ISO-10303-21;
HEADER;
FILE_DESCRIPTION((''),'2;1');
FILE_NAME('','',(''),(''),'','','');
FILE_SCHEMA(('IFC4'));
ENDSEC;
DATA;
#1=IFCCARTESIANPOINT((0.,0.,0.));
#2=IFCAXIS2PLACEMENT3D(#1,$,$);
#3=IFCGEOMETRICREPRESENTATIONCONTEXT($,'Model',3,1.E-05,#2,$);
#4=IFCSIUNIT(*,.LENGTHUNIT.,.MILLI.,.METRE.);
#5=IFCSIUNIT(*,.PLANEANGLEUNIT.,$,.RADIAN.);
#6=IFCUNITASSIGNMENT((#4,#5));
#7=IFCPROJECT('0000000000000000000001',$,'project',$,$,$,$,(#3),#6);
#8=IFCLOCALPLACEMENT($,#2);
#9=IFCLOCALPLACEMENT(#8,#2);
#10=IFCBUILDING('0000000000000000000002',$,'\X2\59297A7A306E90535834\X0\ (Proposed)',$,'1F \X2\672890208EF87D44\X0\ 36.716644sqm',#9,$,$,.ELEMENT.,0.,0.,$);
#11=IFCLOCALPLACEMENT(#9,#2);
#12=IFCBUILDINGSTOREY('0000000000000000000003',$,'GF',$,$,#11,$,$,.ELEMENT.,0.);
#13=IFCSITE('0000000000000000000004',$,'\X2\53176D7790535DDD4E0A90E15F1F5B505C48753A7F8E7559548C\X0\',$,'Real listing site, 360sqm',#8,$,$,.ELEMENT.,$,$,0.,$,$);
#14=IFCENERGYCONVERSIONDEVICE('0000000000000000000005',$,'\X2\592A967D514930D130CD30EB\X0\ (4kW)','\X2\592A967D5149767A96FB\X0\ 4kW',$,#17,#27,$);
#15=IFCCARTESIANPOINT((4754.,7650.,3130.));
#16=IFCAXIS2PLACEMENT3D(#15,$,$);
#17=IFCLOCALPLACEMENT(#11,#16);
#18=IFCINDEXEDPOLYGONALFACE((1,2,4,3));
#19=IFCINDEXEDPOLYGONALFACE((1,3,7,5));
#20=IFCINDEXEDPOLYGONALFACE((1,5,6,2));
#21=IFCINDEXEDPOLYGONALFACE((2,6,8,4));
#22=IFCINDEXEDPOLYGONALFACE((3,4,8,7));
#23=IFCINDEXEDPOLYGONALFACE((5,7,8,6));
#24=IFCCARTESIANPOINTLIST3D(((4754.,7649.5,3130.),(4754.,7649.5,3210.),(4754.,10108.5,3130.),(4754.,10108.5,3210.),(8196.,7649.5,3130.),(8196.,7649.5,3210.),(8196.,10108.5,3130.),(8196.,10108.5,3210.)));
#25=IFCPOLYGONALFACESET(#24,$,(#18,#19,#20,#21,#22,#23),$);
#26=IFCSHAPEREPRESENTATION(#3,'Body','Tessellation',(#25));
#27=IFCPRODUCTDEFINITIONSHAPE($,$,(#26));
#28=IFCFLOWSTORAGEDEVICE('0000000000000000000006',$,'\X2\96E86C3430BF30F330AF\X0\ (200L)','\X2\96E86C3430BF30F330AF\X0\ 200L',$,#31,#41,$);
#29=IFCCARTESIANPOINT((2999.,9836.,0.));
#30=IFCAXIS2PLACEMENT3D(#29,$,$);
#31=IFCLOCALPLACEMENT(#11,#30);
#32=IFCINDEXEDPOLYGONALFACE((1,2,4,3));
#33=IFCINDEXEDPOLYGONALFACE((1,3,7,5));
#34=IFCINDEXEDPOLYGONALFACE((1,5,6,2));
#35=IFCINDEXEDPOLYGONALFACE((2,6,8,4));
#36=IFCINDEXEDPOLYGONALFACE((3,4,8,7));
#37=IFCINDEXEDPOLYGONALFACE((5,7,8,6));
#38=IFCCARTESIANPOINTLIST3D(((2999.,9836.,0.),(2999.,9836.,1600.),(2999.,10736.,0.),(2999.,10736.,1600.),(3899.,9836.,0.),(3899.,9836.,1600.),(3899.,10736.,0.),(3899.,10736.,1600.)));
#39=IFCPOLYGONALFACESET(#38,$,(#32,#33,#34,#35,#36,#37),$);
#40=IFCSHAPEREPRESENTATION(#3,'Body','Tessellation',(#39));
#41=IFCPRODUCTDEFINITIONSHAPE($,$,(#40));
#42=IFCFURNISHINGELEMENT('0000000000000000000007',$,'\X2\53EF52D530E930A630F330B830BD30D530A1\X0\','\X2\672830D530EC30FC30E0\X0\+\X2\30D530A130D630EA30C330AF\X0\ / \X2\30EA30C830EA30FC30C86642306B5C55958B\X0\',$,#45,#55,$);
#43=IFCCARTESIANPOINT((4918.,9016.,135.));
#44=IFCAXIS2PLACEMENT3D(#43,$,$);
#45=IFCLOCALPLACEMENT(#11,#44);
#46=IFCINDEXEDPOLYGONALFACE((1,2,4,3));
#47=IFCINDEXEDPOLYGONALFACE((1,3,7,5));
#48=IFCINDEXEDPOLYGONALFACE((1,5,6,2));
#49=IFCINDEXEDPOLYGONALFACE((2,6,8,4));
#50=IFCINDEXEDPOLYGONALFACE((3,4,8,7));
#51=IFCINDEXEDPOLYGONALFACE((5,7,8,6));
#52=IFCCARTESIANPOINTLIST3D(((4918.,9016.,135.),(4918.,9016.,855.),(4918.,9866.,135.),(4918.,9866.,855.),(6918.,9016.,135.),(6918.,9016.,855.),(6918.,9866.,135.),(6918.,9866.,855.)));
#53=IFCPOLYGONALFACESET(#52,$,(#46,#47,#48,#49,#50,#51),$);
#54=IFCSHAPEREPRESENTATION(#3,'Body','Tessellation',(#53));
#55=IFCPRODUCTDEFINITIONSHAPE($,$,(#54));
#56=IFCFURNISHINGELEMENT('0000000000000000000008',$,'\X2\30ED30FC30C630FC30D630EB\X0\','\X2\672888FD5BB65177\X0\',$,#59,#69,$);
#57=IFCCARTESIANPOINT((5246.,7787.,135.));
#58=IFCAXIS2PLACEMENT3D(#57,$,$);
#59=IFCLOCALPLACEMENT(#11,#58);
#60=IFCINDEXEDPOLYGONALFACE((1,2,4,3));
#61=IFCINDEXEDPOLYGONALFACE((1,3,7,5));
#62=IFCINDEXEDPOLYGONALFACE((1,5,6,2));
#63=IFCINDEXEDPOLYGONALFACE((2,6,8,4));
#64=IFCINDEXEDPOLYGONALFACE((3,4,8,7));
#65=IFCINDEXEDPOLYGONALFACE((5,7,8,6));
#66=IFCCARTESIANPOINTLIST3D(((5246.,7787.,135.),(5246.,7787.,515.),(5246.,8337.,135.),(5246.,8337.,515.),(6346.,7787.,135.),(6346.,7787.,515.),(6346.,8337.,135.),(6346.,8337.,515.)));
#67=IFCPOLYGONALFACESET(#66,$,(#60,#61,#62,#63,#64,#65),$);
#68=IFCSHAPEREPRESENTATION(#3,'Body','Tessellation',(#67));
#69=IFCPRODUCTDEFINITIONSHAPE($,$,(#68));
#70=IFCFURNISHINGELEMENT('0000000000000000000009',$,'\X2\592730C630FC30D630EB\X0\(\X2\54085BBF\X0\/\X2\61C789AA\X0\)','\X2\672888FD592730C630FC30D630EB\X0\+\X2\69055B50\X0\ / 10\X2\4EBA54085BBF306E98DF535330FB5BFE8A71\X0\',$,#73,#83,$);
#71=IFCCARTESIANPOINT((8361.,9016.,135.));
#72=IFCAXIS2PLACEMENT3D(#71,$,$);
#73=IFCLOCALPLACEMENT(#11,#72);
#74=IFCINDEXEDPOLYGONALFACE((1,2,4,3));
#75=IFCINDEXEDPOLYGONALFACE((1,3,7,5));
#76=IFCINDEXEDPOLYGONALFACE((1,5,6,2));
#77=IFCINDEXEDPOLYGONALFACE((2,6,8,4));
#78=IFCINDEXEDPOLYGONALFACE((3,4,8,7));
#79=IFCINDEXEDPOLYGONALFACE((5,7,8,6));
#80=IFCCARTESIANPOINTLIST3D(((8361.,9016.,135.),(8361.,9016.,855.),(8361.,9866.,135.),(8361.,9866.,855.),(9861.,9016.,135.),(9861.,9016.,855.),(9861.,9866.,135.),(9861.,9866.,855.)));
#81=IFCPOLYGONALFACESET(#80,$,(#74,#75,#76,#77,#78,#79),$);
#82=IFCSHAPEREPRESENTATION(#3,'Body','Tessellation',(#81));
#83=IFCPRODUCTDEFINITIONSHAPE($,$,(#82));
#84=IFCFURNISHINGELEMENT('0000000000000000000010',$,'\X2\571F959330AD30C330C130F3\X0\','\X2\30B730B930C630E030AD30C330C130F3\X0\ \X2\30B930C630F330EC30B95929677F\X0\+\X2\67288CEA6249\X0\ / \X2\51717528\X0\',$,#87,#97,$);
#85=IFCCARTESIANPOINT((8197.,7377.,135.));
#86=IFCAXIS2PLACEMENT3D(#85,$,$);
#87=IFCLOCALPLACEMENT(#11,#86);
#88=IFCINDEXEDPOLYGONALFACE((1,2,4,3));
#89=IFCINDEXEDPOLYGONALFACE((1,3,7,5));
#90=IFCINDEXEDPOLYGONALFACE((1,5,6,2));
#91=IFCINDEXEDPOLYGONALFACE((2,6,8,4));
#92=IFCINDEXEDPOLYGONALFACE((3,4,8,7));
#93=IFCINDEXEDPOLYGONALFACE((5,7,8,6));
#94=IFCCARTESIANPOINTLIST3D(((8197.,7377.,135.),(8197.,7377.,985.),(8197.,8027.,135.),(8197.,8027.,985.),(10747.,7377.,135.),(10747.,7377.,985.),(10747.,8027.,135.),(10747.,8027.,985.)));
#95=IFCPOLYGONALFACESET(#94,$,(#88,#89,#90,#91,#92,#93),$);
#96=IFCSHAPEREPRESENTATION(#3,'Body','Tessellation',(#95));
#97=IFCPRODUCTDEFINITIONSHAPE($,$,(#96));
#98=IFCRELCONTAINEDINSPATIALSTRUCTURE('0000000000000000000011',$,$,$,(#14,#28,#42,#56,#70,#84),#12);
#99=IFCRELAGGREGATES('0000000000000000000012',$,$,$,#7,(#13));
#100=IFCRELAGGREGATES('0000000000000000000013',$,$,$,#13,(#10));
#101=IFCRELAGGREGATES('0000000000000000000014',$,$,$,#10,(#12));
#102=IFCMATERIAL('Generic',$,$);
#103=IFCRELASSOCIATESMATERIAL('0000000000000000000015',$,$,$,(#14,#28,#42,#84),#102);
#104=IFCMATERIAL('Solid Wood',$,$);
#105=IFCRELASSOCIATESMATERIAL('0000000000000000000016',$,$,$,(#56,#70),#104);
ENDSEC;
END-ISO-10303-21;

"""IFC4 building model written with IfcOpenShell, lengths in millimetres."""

from ifc_helpers import new_model, si_unit, frame, frame_2d, origin, place, context, project, spatial, rectangle, extrude, material, element, save


model = new_model("IFC4")

# Units and contexts
model_context = context("Model", 3, precision=1e-05, world=origin())
ifc_project = project(units=[si_unit("LENGTHUNIT", "METRE", prefix="MILLI"), si_unit("PLANEANGLEUNIT", "RADIAN")], contexts=[model_context])

# Site, building, storey
site_placement = place(None, origin())
site = spatial("IfcSite", under=ifc_project, at=site_placement, Name="北海道川上郡弟子屈町美留和", ObjectType="Real listing site, 360sqm", CompositionType="ELEMENT", RefElevation=0.0)
building_placement = place(site_placement, origin())
building = spatial("IfcBuilding", under=site, at=building_placement, Name="天空の道場 (Proposed)", ObjectType="1F 木造軸組 36.716644sqm", CompositionType="ELEMENT", ElevationOfRefHeight=0.0, ElevationOfTerrain=0.0)
storey_placement = place(building_placement, origin())
storey = spatial("IfcBuildingStorey", under=building, at=storey_placement, Name="GF", CompositionType="ELEMENT", Elevation=0.0)

# Shared definitions
ifc_material_1 = material(Name="Generic")

# Shared definitions
ifc_material_2 = material(Name="Solid Wood")

# Energy conversion device
energy_conversion_device_placement = place(storey_placement, frame((4754.0, 7650.0, 3130.0)))
element("IfcEnergyConversionDevice", 1, at=energy_conversion_device_placement, inside=storey, material=ifc_material_1, Name="太陽光パネル (4kW)", Description="太陽光発電 4kW", context=model_context, shape_type="SweptSolid", body=[
    extrude(rectangle(XDim=3442.0, YDim=2459.0, at=frame_2d((1721.0, 1229.0))), frame((4754.0, 7650.0, 3130.0)), (0.0, 0.0, 1.0), 80.0),
])

# Flow storage device
flow_storage_device_placement = place(storey_placement, frame((2999.0, 9836.0, 0.0)))
element("IfcFlowStorageDevice", 2, at=flow_storage_device_placement, inside=storey, material=ifc_material_1, Name="雨水タンク (200L)", Description="雨水タンク 200L", context=model_context, shape_type="SweptSolid", body=[
    extrude(rectangle(XDim=900.0, YDim=900.0, at=frame_2d((450.0, 450.0))), frame((2999.0, 9836.0, 0.0)), (0.0, 0.0, 1.0), 1600.0),
])

# Furnishing elements
furnishing_1_placement = place(storey_placement, frame((4918.0, 9016.0, 135.0)))
element("IfcFurnishingElement", 3, at=furnishing_1_placement, inside=storey, material=ifc_material_1, Name="可動ラウンジソファ", Description="木フレーム+ファブリック / リトリート時に展開", context=model_context, shape_type="SweptSolid", body=[
    extrude(rectangle(XDim=2000.0, YDim=850.0, at=frame_2d((1000.0, 425.0))), frame((4918.0, 9016.0, 135.0)), (0.0, 0.0, 1.0), 720.0),
])
furnishing_2_placement = place(storey_placement, frame((5246.0, 7787.0, 135.0)))
element("IfcFurnishingElement", 4, at=furnishing_2_placement, inside=storey, material=ifc_material_2, Name="ローテーブル", Description="木製家具", context=model_context, shape_type="SweptSolid", body=[
    extrude(rectangle(XDim=1100.0, YDim=550.0, at=frame_2d((550.0, 275.0))), frame((5246.0, 7787.0, 135.0)), (0.0, 0.0, 1.0), 380.0),
])
furnishing_3_placement = place(storey_placement, frame((8361.0, 9016.0, 135.0)))
element("IfcFurnishingElement", 5, at=furnishing_3_placement, inside=storey, material=ifc_material_2, Name="大テーブル(合宿/懇親)", Description="木製大テーブル+椅子 / 10人合宿の食卓・対話", context=model_context, shape_type="SweptSolid", body=[
    extrude(rectangle(XDim=1500.0, YDim=850.0, at=frame_2d((750.0, 425.0))), frame((8361.0, 9016.0, 135.0)), (0.0, 0.0, 1.0), 720.0),
])
furnishing_4_placement = place(storey_placement, frame((8197.0, 7377.0, 135.0)))
element("IfcFurnishingElement", 6, at=furnishing_4_placement, inside=storey, material=ifc_material_1, Name="土間キッチン", Description="システムキッチン ステンレス天板+木質扉 / 共用", context=model_context, shape_type="SweptSolid", body=[
    extrude(rectangle(XDim=2550.0, YDim=650.0, at=frame_2d((1275.0, 325.0))), frame((8197.0, 7377.0, 135.0)), (0.0, 0.0, 1.0), 850.0),
])

save(model, "model.ifc")
